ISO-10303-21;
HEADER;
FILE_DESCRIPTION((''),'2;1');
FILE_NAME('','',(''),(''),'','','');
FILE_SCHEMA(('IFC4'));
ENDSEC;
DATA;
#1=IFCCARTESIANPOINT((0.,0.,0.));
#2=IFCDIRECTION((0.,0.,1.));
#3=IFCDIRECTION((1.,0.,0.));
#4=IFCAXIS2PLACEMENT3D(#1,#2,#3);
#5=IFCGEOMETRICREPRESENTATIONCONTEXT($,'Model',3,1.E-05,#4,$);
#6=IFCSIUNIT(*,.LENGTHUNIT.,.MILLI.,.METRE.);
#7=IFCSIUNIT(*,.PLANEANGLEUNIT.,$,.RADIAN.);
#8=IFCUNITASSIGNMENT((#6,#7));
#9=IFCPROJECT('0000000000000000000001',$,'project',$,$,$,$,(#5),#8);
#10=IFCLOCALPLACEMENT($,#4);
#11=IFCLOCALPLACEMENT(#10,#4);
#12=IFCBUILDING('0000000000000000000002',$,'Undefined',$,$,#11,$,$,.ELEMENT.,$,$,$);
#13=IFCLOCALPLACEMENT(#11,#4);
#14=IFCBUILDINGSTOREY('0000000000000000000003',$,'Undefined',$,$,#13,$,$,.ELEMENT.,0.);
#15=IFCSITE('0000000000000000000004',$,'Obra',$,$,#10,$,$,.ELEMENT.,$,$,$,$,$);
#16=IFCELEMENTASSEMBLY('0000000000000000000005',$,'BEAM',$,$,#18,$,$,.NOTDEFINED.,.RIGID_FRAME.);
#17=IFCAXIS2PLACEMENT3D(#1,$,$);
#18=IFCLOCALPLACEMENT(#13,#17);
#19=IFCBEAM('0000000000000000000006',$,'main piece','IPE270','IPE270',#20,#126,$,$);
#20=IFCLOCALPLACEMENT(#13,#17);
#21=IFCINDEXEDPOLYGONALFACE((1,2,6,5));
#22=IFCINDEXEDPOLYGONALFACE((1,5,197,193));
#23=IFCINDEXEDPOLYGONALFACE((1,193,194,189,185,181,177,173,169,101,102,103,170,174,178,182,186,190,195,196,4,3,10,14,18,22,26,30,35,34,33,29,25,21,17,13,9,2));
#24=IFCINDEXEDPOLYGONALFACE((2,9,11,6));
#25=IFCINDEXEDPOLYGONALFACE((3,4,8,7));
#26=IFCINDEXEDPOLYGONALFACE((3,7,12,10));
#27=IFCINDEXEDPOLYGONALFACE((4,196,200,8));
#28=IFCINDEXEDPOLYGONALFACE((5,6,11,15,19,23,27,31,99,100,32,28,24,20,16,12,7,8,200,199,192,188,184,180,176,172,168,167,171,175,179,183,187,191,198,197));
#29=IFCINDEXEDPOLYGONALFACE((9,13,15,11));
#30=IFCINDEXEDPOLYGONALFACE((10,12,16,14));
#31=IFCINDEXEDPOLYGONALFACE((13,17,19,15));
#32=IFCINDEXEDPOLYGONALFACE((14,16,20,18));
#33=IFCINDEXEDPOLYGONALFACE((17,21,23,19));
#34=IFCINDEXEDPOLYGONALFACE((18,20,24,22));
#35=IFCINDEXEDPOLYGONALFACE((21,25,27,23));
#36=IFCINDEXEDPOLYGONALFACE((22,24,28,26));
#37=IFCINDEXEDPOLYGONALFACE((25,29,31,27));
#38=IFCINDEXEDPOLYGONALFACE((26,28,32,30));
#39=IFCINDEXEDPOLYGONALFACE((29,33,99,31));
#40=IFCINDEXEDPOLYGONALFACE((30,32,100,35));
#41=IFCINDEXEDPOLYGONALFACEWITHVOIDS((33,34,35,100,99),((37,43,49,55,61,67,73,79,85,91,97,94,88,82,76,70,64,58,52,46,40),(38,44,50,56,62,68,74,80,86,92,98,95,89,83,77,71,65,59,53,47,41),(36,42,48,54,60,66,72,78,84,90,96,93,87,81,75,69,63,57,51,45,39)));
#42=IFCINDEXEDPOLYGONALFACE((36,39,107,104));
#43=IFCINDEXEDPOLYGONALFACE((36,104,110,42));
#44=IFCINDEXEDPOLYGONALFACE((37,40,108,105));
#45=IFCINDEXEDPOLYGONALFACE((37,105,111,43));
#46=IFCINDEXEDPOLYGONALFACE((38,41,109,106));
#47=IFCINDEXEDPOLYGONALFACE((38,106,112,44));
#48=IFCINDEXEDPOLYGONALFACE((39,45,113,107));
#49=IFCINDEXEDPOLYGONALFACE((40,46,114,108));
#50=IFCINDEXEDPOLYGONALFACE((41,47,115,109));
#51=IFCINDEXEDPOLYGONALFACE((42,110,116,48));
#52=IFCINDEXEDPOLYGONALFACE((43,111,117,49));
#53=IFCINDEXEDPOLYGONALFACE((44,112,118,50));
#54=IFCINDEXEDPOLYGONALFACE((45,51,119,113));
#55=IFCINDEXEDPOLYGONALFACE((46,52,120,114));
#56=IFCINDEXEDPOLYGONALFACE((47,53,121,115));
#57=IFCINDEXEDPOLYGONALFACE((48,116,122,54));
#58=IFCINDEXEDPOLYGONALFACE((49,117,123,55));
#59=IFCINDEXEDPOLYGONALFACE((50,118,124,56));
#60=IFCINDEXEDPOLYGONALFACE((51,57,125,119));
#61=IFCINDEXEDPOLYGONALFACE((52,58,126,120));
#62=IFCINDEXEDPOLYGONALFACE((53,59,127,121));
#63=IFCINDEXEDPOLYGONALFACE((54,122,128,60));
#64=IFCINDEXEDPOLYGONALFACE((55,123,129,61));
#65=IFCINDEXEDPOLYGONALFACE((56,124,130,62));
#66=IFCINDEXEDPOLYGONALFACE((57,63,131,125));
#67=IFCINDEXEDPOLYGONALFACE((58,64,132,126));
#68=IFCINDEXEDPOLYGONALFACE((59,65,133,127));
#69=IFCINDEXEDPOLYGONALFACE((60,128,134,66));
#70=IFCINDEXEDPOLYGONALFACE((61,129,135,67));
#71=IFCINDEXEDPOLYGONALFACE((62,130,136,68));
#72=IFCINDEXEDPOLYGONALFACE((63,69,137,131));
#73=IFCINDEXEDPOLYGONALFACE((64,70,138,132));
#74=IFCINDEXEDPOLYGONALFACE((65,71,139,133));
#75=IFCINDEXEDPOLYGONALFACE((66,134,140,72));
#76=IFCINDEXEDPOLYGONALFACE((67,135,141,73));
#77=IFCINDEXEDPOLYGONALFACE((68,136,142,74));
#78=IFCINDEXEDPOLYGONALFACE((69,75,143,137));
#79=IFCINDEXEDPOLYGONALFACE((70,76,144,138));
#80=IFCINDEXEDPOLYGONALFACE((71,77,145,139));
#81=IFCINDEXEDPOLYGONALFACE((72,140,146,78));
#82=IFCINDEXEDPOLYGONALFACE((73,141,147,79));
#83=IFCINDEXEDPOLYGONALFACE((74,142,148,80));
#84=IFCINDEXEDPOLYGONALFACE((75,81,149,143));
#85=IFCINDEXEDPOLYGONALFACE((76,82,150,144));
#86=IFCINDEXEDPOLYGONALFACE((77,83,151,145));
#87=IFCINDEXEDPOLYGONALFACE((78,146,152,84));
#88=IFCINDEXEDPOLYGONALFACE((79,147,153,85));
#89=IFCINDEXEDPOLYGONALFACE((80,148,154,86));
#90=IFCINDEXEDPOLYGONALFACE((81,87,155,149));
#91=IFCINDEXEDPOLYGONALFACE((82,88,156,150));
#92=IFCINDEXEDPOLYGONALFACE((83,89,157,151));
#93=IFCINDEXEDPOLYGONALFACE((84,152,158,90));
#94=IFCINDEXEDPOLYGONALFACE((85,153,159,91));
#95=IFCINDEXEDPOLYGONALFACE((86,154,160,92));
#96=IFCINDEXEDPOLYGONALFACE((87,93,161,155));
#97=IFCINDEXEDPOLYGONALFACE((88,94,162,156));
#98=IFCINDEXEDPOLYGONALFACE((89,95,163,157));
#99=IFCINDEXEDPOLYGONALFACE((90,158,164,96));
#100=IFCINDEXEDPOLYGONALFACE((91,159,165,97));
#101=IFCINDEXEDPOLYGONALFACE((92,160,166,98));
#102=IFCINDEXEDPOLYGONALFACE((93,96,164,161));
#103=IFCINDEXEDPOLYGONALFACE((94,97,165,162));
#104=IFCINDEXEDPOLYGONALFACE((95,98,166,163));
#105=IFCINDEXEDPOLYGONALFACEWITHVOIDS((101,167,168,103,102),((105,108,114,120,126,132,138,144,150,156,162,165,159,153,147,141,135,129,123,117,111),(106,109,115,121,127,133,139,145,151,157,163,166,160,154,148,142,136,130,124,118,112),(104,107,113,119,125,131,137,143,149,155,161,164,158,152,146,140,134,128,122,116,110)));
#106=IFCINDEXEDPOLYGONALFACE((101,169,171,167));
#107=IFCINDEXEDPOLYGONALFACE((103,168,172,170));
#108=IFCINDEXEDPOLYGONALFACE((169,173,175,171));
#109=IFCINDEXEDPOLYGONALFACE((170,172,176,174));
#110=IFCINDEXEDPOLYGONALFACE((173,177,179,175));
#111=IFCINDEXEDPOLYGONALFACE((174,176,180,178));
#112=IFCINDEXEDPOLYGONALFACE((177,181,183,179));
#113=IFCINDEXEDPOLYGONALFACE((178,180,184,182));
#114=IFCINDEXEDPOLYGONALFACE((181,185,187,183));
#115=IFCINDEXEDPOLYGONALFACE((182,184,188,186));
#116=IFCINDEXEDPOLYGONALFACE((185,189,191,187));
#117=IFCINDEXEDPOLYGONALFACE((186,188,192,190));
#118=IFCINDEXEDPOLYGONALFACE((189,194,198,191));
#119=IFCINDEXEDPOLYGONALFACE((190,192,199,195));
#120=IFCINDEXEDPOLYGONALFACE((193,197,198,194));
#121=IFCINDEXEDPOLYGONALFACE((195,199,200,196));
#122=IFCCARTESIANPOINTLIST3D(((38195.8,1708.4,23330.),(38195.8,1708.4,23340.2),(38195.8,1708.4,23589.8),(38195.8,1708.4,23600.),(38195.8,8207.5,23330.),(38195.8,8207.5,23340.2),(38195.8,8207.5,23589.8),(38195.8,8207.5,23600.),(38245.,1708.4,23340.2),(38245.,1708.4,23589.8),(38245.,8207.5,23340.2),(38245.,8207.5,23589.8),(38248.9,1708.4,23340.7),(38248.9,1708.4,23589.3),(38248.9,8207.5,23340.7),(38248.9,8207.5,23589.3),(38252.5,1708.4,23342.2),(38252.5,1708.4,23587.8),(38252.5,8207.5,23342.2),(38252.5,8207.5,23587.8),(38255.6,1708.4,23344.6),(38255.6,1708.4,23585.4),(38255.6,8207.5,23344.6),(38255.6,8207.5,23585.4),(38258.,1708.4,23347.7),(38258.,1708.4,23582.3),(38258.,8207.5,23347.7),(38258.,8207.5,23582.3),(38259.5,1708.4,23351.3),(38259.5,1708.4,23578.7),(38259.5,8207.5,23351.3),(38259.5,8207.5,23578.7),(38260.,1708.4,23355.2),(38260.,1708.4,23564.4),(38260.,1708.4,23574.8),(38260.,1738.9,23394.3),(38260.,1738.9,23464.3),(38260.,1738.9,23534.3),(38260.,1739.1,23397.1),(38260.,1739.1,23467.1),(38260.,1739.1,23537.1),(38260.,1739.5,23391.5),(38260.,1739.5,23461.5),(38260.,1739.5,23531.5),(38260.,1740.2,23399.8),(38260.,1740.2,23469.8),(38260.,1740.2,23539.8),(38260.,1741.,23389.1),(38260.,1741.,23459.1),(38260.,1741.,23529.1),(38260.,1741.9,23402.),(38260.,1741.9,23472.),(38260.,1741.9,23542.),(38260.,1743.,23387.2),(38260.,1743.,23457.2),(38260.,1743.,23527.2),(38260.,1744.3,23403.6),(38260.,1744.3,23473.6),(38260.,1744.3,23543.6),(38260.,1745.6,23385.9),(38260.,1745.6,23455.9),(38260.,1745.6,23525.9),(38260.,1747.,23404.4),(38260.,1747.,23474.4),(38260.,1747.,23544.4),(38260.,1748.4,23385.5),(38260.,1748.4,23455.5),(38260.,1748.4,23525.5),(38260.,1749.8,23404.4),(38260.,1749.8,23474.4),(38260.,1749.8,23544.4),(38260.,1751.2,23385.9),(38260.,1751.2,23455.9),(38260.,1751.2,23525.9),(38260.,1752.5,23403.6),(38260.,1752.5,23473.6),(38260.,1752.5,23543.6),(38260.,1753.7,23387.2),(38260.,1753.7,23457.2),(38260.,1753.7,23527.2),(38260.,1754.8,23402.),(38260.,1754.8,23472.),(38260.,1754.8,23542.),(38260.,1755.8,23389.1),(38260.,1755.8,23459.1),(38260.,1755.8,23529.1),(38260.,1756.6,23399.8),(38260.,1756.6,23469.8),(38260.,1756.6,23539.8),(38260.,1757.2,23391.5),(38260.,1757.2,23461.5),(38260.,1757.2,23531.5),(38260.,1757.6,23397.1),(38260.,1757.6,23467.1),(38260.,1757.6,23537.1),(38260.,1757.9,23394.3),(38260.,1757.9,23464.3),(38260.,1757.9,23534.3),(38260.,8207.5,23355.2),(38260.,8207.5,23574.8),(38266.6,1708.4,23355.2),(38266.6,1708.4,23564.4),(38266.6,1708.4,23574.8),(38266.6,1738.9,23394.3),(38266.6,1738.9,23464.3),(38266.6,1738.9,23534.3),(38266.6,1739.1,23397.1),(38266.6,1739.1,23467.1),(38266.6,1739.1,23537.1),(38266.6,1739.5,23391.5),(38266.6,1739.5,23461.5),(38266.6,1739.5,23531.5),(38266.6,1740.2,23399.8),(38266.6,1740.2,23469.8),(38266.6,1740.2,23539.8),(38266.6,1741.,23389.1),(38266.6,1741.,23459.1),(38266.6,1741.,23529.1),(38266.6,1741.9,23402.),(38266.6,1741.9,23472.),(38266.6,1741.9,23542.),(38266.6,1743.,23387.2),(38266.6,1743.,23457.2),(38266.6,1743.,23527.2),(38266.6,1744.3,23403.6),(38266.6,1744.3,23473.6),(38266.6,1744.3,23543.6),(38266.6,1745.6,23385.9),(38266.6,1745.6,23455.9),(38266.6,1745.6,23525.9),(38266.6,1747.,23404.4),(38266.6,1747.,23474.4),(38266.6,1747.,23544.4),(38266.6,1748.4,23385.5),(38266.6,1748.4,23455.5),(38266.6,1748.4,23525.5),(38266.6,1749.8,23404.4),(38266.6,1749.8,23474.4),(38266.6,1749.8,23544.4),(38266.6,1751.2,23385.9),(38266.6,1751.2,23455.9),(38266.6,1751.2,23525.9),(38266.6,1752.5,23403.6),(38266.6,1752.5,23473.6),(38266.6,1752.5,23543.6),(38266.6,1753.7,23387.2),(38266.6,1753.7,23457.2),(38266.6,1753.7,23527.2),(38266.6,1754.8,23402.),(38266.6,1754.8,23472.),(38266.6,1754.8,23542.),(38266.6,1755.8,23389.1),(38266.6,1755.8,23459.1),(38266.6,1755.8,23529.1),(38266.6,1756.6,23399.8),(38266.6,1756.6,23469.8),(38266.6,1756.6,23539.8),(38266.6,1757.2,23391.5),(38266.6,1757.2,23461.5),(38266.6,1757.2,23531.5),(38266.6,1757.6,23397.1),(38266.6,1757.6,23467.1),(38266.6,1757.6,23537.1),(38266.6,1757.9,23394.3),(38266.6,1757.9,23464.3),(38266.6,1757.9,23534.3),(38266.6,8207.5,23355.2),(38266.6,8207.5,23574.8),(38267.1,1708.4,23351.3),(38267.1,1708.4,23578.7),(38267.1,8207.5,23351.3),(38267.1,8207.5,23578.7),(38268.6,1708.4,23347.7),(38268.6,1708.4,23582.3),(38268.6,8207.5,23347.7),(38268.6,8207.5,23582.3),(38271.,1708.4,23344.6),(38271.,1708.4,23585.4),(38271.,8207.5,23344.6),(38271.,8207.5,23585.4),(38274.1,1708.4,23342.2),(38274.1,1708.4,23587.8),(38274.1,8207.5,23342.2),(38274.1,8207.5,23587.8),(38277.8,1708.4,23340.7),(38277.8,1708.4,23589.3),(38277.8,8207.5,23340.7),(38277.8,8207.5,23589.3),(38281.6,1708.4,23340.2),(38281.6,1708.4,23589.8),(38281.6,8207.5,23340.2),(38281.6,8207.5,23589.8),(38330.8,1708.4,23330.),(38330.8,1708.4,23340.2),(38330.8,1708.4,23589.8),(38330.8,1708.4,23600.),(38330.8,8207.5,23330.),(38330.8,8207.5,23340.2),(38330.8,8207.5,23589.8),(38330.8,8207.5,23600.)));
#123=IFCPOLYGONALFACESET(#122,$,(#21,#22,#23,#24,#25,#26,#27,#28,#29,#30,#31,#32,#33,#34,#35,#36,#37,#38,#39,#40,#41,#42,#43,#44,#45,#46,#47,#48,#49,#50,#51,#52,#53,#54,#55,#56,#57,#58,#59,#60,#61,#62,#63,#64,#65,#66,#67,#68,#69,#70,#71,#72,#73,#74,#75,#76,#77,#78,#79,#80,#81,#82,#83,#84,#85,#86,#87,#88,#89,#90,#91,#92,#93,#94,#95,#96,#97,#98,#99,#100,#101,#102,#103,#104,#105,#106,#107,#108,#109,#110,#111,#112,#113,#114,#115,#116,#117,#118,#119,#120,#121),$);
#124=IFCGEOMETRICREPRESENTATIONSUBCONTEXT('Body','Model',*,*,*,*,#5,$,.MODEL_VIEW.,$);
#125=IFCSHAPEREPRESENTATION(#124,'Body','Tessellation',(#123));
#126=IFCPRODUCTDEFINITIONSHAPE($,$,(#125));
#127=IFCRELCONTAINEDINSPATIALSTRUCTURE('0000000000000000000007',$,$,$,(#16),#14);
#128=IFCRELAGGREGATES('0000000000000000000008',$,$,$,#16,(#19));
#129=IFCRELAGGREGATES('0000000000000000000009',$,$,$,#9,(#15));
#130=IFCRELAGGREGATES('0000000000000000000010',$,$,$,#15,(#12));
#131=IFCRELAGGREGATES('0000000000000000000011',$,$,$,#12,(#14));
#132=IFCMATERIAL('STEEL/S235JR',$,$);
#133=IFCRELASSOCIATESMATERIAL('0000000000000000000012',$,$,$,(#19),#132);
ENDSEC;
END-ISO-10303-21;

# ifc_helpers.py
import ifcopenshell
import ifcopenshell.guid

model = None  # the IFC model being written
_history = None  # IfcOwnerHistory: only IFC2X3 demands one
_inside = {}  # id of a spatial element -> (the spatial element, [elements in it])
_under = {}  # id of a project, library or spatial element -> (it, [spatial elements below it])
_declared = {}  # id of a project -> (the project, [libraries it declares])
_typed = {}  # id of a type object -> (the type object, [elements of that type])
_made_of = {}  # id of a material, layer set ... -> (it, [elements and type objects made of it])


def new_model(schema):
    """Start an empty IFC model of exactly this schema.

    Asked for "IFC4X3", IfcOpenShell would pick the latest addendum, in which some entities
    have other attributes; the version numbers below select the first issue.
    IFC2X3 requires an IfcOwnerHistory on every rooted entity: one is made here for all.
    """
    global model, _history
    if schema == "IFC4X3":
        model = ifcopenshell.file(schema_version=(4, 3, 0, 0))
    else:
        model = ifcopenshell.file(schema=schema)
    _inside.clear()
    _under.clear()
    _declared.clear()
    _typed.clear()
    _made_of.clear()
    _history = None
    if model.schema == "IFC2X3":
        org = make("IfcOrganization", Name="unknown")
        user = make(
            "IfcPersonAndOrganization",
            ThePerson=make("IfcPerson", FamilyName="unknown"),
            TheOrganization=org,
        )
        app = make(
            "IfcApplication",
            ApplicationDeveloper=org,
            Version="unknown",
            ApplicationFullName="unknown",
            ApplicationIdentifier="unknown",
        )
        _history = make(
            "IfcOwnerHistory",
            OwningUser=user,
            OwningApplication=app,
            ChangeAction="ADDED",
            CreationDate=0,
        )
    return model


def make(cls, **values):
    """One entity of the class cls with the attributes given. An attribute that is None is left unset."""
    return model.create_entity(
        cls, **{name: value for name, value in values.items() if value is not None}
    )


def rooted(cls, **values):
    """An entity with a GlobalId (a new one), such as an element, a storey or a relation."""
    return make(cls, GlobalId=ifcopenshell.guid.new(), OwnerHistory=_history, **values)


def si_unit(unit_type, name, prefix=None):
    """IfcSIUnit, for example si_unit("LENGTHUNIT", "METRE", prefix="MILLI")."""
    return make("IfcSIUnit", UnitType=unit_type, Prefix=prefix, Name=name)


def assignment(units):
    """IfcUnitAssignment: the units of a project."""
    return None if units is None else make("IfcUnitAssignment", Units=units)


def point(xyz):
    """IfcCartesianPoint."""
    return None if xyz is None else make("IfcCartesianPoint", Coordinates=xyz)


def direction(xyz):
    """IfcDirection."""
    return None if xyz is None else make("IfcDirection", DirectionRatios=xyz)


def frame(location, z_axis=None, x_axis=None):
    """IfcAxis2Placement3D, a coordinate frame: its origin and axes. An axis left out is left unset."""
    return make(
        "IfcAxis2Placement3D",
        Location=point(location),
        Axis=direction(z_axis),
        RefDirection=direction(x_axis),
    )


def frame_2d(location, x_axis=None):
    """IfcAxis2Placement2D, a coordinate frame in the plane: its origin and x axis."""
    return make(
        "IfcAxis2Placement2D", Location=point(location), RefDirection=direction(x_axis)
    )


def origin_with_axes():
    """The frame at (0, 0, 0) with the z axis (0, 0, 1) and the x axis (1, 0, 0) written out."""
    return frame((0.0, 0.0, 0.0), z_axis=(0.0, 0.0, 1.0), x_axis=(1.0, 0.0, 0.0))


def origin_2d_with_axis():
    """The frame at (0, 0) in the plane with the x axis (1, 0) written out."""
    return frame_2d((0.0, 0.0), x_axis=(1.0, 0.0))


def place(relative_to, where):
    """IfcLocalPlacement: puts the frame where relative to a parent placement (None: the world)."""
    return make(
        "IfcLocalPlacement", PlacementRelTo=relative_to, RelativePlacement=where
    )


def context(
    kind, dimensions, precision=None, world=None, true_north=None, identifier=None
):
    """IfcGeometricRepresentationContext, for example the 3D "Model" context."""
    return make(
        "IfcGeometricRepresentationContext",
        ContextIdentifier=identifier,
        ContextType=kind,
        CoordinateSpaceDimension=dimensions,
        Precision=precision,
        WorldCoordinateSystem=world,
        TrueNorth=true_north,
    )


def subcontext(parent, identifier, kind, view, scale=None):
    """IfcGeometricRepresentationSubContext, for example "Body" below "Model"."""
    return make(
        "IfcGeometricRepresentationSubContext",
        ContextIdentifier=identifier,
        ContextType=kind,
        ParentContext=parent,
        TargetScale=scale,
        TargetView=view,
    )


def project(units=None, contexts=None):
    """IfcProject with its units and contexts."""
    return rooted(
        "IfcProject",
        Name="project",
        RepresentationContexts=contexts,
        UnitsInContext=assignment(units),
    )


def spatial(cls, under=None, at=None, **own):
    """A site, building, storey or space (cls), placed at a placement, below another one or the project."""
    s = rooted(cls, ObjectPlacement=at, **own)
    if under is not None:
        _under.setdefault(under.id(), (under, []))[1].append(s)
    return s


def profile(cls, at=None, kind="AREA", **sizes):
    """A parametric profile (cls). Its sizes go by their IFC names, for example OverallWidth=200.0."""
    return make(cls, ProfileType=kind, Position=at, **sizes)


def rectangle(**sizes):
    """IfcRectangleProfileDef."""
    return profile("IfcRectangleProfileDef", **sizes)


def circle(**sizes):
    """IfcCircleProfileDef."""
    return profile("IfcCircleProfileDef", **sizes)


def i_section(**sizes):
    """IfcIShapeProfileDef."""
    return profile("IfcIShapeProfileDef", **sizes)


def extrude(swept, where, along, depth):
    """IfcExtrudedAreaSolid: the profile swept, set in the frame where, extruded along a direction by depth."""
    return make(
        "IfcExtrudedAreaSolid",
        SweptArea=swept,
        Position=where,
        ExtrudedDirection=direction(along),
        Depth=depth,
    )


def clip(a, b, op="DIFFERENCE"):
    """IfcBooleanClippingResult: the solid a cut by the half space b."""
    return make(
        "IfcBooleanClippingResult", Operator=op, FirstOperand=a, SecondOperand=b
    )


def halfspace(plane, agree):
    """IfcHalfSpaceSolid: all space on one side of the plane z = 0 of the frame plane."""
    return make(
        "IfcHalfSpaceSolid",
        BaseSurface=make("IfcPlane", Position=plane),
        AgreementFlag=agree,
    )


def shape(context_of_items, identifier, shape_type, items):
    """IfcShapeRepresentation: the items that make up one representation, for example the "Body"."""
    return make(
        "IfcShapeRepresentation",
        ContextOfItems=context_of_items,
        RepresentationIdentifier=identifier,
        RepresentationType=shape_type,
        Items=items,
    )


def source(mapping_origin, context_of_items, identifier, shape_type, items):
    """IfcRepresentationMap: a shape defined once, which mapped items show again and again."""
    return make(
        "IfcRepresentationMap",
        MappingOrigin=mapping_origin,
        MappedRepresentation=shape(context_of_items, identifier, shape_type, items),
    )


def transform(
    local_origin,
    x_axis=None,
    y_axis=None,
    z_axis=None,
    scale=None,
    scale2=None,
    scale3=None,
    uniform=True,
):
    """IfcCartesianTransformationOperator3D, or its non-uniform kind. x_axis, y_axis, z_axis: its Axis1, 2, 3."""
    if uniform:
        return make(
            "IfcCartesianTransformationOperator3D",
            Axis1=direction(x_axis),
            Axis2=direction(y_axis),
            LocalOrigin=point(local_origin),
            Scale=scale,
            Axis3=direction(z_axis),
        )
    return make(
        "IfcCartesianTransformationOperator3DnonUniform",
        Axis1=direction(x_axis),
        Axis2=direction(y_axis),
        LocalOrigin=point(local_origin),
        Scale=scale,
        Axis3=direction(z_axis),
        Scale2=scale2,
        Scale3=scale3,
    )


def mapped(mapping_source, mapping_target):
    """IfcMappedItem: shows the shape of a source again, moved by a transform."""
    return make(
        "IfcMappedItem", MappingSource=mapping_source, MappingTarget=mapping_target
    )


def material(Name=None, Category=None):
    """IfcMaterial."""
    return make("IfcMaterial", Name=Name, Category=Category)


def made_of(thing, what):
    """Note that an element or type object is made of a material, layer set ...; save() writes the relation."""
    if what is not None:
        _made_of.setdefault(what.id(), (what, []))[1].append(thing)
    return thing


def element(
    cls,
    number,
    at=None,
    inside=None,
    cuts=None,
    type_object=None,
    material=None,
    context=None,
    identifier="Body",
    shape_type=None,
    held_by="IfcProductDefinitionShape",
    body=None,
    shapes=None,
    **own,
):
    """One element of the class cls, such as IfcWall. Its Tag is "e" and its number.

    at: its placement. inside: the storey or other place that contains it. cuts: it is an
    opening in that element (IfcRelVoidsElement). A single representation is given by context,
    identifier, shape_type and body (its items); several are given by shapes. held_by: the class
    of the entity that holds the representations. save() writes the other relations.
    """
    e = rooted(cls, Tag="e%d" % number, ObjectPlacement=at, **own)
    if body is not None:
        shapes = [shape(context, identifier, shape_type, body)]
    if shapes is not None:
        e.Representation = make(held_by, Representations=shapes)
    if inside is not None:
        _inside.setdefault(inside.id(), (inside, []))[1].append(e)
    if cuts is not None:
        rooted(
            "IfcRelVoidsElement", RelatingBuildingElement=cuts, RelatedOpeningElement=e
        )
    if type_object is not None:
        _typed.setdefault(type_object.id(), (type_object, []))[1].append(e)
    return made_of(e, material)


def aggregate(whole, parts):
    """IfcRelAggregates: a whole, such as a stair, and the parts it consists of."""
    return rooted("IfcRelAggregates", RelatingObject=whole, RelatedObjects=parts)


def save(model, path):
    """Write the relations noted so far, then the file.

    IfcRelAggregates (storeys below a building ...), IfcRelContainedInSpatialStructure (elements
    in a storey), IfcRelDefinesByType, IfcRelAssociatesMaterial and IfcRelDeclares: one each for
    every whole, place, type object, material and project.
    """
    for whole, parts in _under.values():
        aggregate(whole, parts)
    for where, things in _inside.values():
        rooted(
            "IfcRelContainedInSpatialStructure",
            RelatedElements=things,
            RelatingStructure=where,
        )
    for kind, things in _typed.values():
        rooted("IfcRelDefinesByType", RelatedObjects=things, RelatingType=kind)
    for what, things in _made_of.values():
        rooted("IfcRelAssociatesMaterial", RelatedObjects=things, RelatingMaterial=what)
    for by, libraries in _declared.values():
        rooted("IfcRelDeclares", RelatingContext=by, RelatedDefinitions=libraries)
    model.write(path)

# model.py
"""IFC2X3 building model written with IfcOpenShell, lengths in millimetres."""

from ifc_helpers import new_model, si_unit, frame, origin_with_axes, origin_2d_with_axis, place, context, subcontext, project, spatial, rectangle, circle, i_section, extrude, clip, halfspace, source, transform, mapped, material, element, aggregate, save


model = new_model("IFC2X3")

# Units and contexts
model_context = context("Model", 3, precision=1e-05, world=origin_with_axes())
body_context = subcontext(model_context, "Body", "Model", "MODEL_VIEW")
ifc_project = project(units=[si_unit("LENGTHUNIT", "METRE", prefix="MILLI"), si_unit("PLANEANGLEUNIT", "RADIAN")], contexts=[model_context])

# Site, building, storey
site_placement = place(None, origin_with_axes())
site = spatial("IfcSite", under=ifc_project, at=site_placement, Name="Obra", CompositionType="ELEMENT")
building_placement = place(site_placement, origin_with_axes())
building = spatial("IfcBuilding", under=site, at=building_placement, Name="Undefined", CompositionType="ELEMENT")
storey_placement = place(building_placement, origin_with_axes())
storey = spatial("IfcBuildingStorey", under=building, at=storey_placement, Name="Undefined", CompositionType="ELEMENT", Elevation=0.0)

# Shared definitions
ifc_material_1 = material(Name="STEEL/S235JR")

# Element assembly, beam, openings
shared_shape_1 = source(origin_with_axes(), body_context, "Body", "SweptSolid", [
    extrude(circle(Radius=9.5, at=origin_2d_with_axis()), frame((0.0, -3.4, 0.0), z_axis=(0.0, 1.0, 0.0), x_axis=(1.0, 0.0, 0.0)), (0.0, 0.0, 1.0), 6.8),
])
assembly_1_placement = place(storey_placement, origin_with_axes())
assembly_1 = element("IfcElementAssembly", 1, at=assembly_1_placement, inside=storey, Name="BEAM", AssemblyPlace="NOTDEFINED", PredefinedType="RIGID_FRAME")
beam_1_placement = place(assembly_1_placement, frame((38263.3, 1711.1, 23465.0), z_axis=(0.0, 0.0, 1.0), x_axis=(0.0, 1.0, 0.0)))
beam_1 = element("IfcBeam", 2, at=beam_1_placement, material=ifc_material_1, Name="main piece", Description="IPE270", ObjectType="IPE270", context=body_context, shape_type="Clipping", body=[
    clip(clip(extrude(i_section(OverallWidth=135.0, OverallDepth=270.0, WebThickness=6.6, FlangeThickness=10.2, FilletRadius=15.0, at=origin_2d_with_axis()), frame((6536.0, 0.0, 0.0), z_axis=(-1.0, 0.0, 0.0), x_axis=(0.0, -1.0, 0.0)), (0.0, 0.0, 1.0), 6538.7), halfspace(frame((6496.4, -60.0, -120.0), z_axis=(1.0, 0.0, 0.0), x_axis=(0.0, 0.0, 1.0)), False)), halfspace(frame((-2.7, 0.0, -235.0), z_axis=(1.0, 0.0, 0.0), x_axis=(0.0, -1.0, 0.0)), True)),
])
opening_1_placement = place(assembly_1_placement, frame((38263.3, 1711.1, 23465.0), z_axis=(0.0, 0.0, 1.0), x_axis=(0.0, 1.0, 0.0)))
element("IfcOpeningElement", 3, at=opening_1_placement, cuts=beam_1, ObjectType="Recess", context=body_context, shape_type="SweptSolid", body=[
    extrude(rectangle(XDim=36.6, YDim=102.3, at=origin_2d_with_axis()), frame((-53.9, -68.5, 117.7), z_axis=(0.0, 1.0, 0.0), x_axis=(0.0, 0.0, -1.0)), (0.0, 0.0, 1.0), 137.0),
])
opening_2_placement = place(assembly_1_placement, frame((38263.3, 1708.4, 23570.0), z_axis=(0.0, 1.0, 0.0), x_axis=(0.0, 0.0, -1.0)))
element("IfcOpeningElement", 4, at=opening_2_placement, cuts=beam_1, ObjectType="Opening", context=body_context, shape_type="MappedRepresentation", body=[
    mapped(shared_shape_1, transform((35.0, 0.0, 40.0))),
    mapped(shared_shape_1, transform((105.0, 0.0, 40.0))),
    mapped(shared_shape_1, transform((175.0, 0.0, 40.0))),
])

aggregate(assembly_1, [beam_1])

save(model, "model.ifc")
